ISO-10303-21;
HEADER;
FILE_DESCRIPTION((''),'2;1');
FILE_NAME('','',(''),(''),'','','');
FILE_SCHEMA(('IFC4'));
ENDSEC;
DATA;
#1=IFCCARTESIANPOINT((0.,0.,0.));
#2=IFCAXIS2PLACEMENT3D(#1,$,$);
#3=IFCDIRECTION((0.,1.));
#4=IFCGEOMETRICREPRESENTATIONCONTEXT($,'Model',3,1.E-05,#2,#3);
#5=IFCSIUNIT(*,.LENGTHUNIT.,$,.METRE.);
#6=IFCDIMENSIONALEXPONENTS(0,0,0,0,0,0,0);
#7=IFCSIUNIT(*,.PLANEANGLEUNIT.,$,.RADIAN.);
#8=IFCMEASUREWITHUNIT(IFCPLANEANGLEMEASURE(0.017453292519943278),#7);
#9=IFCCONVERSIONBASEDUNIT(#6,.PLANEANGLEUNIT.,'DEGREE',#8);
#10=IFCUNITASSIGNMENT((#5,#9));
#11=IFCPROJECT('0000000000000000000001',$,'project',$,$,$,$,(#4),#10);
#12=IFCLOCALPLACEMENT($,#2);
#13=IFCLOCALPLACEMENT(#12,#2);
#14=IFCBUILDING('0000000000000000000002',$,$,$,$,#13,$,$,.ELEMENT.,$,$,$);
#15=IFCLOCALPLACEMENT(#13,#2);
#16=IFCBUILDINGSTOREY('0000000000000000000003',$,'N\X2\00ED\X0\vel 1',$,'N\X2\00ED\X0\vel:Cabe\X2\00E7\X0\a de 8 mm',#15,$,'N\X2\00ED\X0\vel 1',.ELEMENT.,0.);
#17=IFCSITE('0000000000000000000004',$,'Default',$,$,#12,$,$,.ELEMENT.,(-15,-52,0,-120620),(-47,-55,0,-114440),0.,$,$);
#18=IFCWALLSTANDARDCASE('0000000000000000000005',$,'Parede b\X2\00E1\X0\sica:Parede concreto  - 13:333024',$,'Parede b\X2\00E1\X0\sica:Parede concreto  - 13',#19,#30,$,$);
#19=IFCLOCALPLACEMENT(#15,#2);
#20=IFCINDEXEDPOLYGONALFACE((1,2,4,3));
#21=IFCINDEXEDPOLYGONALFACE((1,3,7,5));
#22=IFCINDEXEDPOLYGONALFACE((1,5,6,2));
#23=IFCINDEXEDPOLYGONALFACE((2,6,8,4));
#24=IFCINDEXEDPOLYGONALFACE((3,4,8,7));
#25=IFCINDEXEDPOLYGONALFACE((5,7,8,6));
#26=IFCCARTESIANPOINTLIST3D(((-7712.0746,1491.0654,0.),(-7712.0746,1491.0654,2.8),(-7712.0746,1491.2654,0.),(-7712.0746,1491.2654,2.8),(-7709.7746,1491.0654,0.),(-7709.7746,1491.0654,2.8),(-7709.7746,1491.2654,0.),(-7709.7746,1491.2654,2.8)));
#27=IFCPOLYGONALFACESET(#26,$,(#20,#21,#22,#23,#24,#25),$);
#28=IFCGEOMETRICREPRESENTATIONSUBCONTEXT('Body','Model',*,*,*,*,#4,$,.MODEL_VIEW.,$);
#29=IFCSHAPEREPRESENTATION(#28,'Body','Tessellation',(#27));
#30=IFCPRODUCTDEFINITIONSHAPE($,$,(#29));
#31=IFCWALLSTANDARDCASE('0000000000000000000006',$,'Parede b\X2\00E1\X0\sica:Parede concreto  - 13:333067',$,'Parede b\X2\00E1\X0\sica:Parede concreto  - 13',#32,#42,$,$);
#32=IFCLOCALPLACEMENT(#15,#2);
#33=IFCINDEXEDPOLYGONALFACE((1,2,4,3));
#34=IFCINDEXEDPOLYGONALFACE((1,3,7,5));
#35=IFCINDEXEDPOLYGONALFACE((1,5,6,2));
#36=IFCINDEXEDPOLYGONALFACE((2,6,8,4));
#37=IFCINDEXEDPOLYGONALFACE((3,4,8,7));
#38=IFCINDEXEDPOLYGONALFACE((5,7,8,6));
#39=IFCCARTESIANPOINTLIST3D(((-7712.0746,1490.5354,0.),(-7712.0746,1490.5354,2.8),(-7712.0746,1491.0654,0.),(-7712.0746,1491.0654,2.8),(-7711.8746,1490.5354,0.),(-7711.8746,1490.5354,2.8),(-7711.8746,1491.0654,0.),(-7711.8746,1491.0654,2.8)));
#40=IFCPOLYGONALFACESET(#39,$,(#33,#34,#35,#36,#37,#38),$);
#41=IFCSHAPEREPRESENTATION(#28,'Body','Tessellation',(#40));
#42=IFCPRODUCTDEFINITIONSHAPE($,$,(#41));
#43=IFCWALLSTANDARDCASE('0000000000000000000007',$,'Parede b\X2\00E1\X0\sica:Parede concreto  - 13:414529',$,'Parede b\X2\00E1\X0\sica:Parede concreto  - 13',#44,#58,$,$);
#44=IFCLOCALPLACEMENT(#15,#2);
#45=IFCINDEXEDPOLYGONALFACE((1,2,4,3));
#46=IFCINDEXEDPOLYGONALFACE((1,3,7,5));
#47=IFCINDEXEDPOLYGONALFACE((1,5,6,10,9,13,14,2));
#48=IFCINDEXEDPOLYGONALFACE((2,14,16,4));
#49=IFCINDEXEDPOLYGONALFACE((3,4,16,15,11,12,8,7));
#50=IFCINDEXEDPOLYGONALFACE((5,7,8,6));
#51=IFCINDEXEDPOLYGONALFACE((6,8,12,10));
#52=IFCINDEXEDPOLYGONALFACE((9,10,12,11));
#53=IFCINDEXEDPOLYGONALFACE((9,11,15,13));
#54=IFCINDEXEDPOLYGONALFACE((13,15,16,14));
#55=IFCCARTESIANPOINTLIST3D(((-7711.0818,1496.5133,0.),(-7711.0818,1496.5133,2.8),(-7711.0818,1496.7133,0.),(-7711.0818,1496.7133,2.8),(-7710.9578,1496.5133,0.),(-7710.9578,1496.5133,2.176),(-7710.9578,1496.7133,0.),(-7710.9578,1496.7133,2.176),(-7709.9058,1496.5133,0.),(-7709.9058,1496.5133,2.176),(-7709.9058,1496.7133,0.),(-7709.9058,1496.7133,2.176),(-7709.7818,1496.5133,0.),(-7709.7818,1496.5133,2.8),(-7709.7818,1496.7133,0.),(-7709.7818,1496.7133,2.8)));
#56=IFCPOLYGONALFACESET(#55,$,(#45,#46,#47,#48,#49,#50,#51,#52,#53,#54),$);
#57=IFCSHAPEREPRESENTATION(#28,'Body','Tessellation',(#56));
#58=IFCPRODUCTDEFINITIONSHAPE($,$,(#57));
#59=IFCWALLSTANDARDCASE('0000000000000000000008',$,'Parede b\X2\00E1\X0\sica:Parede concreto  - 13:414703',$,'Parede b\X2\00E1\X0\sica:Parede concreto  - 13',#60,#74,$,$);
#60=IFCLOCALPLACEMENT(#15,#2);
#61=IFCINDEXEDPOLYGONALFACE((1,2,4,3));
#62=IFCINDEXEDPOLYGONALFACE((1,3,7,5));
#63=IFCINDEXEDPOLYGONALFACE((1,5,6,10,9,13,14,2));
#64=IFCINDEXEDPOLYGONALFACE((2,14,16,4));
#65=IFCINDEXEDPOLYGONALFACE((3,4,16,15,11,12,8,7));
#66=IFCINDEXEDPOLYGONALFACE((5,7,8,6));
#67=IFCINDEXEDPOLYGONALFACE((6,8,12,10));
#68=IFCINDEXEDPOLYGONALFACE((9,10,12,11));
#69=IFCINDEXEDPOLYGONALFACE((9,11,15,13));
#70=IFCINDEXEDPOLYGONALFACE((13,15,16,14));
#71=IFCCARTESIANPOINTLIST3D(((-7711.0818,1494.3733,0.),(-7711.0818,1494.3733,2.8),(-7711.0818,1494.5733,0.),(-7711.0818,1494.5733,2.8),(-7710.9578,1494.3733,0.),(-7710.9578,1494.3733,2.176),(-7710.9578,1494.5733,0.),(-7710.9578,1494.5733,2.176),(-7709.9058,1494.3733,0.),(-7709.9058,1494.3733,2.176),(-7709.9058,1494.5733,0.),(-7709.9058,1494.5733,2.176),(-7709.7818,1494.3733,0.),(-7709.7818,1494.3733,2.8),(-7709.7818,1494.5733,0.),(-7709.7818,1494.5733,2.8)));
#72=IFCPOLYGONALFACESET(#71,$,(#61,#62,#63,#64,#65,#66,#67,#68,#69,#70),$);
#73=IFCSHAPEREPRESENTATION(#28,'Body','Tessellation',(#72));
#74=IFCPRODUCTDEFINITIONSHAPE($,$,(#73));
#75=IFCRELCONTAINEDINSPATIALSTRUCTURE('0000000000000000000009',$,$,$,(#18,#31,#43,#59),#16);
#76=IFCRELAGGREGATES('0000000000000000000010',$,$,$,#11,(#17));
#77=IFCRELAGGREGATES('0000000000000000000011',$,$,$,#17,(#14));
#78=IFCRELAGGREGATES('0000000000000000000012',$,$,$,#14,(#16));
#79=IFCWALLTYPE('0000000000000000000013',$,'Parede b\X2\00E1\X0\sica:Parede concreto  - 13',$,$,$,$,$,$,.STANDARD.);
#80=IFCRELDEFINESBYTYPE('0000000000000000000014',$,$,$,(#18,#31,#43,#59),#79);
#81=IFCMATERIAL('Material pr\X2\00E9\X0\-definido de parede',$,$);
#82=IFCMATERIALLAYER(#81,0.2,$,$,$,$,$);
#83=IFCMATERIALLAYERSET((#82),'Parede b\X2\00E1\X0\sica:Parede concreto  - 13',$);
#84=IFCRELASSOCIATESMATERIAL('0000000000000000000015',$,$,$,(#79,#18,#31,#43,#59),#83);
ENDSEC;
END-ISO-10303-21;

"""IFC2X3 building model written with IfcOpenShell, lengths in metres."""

from ifc_helpers import new_model, entity, si_unit, converted_unit, direction, frame, frame_2d, origin, place, context, subcontext, project, spatial, rectangle, extrude, material, layer, layer_set, layer_usage, type_object, element, save


model = new_model("IFC2X3")

# Units and contexts
model_context = context("Model", 3, precision=1e-05, world=origin(), true_north=direction((0.0, 1.0)))
body_context = subcontext(model_context, "Body", "Model", "MODEL_VIEW")
ifc_project = project(units=[si_unit("LENGTHUNIT", "METRE"), converted_unit("PLANEANGLEUNIT", "DEGREE", entity("IfcPlaneAngleMeasure", 0.017453292519943278), si_unit("PLANEANGLEUNIT", "RADIAN"), dimensions=[0, 0, 0, 0, 0, 0, 0])], contexts=[model_context])

# Site, building, storey
site_placement = place(None, origin())
site = spatial("IfcSite", under=ifc_project, at=site_placement, Name="Default", CompositionType="ELEMENT", RefLatitude=(-15, -52, 0, -120620), RefLongitude=(-47, -55, 0, -114440), RefElevation=0.0)
building_placement = place(site_placement, origin())
building = spatial("IfcBuilding", under=site, at=building_placement, CompositionType="ELEMENT")
storey_placement = place(building_placement, origin())
storey = spatial("IfcBuildingStorey", under=building, at=storey_placement, Name="Nível 1", ObjectType="Nível:Cabeça de 8 mm", LongName="Nível 1", CompositionType="ELEMENT", Elevation=0.0)

# Shared definitions
ifc_material = material(Name="Material pré-definido de parede")
ifc_layer = layer(ifc_material, 0.2)
ifc_layer_set = layer_set([ifc_layer], Name="Parede básica:Parede concreto  - 13")
wall_type = type_object("IfcWallType", Name="Parede básica:Parede concreto  - 13", PredefinedType="STANDARD", material=ifc_layer_set)

# Walls
ifc_layer_usage_1 = layer_usage(ifc_layer_set, "AXIS2", "NEGATIVE", 0.1)
wall_1_placement = place(storey_placement, frame((-7709.7746, 1491.1654, 0.0), z_axis=(0.0, 0.0, 1.0), x_axis=(-1.0, 0.0, 0.0)))
element("IfcWallStandardCase", 1, at=wall_1_placement, inside=storey, type_object=wall_type, material=ifc_layer_usage_1, Name="Parede básica:Parede concreto  - 13:333024", ObjectType="Parede básica:Parede concreto  - 13", context=body_context, shape_type="SweptSolid", body=[
    extrude(rectangle(XDim=2.3, YDim=0.2, at=frame_2d((1.15, 0.0), x_axis=(-1.0, 0.0))), origin(), (0.0, 0.0, 1.0), 2.8),
])
ifc_layer_usage_2 = layer_usage(ifc_layer_set, "AXIS2", "POSITIVE", -0.1)
wall_2_placement = place(storey_placement, frame((-7711.9746, 1491.0654, 0.0), z_axis=(0.0, 0.0, 1.0), x_axis=(0.0, -1.0, 0.0)))
element("IfcWallStandardCase", 2, at=wall_2_placement, inside=storey, type_object=wall_type, material=ifc_layer_usage_2, Name="Parede básica:Parede concreto  - 13:333067", ObjectType="Parede básica:Parede concreto  - 13", context=body_context, shape_type="SweptSolid", body=[
    extrude(rectangle(XDim=0.53, YDim=0.2, at=frame_2d((0.265, 0.0), x_axis=(-1.0, 0.0))), origin(), (0.0, 0.0, 1.0), 2.8),
])

# Walls, openings
ifc_layer_usage_3 = layer_usage(ifc_layer_set, "AXIS2", "POSITIVE", -0.1)
wall_3_placement = place(storey_placement, frame((-7711.0818, 1496.6133, 0.0)))
wall_3 = element("IfcWallStandardCase", 3, at=wall_3_placement, inside=storey, type_object=wall_type, material=ifc_layer_usage_3, Name="Parede básica:Parede concreto  - 13:414529", ObjectType="Parede básica:Parede concreto  - 13", context=body_context, shape_type="SweptSolid", body=[
    extrude(rectangle(XDim=1.3, YDim=0.2, at=frame_2d((0.65, 0.0), x_axis=(-1.0, 0.0))), origin(), (0.0, 0.0, 1.0), 2.8),
])
opening_1_placement = place(wall_3_placement, origin())
element("IfcOpeningElement", 4, at=opening_1_placement, cuts=wall_3, ObjectType="Opening", context=body_context, shape_type="SweptSolid", body=[
    extrude(rectangle(XDim=2.176, YDim=1.052, at=frame_2d((0.0, 0.0), x_axis=(0.0, 1.0))), frame((0.65, 0.1, 1.088), z_axis=(0.0, -1.0, 0.0), x_axis=(1.0, 0.0, 0.0)), (0.0, 0.0, 1.0), 0.2),
])
ifc_layer_usage_4 = layer_usage(ifc_layer_set, "AXIS2", "POSITIVE", -0.1)
wall_4_placement = place(storey_placement, frame((-7711.0818, 1494.4733, 0.0)))
wall_4 = element("IfcWallStandardCase", 5, at=wall_4_placement, inside=storey, type_object=wall_type, material=ifc_layer_usage_4, Name="Parede básica:Parede concreto  - 13:414703", ObjectType="Parede básica:Parede concreto  - 13", context=body_context, shape_type="SweptSolid", body=[
    extrude(rectangle(XDim=1.3, YDim=0.2, at=frame_2d((0.65, 0.0), x_axis=(-1.0, 0.0))), origin(), (0.0, 0.0, 1.0), 2.8),
])
opening_2_placement = place(wall_4_placement, origin())
element("IfcOpeningElement", 6, at=opening_2_placement, cuts=wall_4, ObjectType="Opening", context=body_context, shape_type="SweptSolid", body=[
    extrude(rectangle(XDim=2.176, YDim=1.052, at=frame_2d((0.0, 0.0), x_axis=(0.0, 1.0))), frame((0.65, 0.1, 1.088), z_axis=(0.0, -1.0, 0.0), x_axis=(1.0, 0.0, 0.0)), (0.0, 0.0, 1.0), 0.2),
])

save(model, "model.ifc")
